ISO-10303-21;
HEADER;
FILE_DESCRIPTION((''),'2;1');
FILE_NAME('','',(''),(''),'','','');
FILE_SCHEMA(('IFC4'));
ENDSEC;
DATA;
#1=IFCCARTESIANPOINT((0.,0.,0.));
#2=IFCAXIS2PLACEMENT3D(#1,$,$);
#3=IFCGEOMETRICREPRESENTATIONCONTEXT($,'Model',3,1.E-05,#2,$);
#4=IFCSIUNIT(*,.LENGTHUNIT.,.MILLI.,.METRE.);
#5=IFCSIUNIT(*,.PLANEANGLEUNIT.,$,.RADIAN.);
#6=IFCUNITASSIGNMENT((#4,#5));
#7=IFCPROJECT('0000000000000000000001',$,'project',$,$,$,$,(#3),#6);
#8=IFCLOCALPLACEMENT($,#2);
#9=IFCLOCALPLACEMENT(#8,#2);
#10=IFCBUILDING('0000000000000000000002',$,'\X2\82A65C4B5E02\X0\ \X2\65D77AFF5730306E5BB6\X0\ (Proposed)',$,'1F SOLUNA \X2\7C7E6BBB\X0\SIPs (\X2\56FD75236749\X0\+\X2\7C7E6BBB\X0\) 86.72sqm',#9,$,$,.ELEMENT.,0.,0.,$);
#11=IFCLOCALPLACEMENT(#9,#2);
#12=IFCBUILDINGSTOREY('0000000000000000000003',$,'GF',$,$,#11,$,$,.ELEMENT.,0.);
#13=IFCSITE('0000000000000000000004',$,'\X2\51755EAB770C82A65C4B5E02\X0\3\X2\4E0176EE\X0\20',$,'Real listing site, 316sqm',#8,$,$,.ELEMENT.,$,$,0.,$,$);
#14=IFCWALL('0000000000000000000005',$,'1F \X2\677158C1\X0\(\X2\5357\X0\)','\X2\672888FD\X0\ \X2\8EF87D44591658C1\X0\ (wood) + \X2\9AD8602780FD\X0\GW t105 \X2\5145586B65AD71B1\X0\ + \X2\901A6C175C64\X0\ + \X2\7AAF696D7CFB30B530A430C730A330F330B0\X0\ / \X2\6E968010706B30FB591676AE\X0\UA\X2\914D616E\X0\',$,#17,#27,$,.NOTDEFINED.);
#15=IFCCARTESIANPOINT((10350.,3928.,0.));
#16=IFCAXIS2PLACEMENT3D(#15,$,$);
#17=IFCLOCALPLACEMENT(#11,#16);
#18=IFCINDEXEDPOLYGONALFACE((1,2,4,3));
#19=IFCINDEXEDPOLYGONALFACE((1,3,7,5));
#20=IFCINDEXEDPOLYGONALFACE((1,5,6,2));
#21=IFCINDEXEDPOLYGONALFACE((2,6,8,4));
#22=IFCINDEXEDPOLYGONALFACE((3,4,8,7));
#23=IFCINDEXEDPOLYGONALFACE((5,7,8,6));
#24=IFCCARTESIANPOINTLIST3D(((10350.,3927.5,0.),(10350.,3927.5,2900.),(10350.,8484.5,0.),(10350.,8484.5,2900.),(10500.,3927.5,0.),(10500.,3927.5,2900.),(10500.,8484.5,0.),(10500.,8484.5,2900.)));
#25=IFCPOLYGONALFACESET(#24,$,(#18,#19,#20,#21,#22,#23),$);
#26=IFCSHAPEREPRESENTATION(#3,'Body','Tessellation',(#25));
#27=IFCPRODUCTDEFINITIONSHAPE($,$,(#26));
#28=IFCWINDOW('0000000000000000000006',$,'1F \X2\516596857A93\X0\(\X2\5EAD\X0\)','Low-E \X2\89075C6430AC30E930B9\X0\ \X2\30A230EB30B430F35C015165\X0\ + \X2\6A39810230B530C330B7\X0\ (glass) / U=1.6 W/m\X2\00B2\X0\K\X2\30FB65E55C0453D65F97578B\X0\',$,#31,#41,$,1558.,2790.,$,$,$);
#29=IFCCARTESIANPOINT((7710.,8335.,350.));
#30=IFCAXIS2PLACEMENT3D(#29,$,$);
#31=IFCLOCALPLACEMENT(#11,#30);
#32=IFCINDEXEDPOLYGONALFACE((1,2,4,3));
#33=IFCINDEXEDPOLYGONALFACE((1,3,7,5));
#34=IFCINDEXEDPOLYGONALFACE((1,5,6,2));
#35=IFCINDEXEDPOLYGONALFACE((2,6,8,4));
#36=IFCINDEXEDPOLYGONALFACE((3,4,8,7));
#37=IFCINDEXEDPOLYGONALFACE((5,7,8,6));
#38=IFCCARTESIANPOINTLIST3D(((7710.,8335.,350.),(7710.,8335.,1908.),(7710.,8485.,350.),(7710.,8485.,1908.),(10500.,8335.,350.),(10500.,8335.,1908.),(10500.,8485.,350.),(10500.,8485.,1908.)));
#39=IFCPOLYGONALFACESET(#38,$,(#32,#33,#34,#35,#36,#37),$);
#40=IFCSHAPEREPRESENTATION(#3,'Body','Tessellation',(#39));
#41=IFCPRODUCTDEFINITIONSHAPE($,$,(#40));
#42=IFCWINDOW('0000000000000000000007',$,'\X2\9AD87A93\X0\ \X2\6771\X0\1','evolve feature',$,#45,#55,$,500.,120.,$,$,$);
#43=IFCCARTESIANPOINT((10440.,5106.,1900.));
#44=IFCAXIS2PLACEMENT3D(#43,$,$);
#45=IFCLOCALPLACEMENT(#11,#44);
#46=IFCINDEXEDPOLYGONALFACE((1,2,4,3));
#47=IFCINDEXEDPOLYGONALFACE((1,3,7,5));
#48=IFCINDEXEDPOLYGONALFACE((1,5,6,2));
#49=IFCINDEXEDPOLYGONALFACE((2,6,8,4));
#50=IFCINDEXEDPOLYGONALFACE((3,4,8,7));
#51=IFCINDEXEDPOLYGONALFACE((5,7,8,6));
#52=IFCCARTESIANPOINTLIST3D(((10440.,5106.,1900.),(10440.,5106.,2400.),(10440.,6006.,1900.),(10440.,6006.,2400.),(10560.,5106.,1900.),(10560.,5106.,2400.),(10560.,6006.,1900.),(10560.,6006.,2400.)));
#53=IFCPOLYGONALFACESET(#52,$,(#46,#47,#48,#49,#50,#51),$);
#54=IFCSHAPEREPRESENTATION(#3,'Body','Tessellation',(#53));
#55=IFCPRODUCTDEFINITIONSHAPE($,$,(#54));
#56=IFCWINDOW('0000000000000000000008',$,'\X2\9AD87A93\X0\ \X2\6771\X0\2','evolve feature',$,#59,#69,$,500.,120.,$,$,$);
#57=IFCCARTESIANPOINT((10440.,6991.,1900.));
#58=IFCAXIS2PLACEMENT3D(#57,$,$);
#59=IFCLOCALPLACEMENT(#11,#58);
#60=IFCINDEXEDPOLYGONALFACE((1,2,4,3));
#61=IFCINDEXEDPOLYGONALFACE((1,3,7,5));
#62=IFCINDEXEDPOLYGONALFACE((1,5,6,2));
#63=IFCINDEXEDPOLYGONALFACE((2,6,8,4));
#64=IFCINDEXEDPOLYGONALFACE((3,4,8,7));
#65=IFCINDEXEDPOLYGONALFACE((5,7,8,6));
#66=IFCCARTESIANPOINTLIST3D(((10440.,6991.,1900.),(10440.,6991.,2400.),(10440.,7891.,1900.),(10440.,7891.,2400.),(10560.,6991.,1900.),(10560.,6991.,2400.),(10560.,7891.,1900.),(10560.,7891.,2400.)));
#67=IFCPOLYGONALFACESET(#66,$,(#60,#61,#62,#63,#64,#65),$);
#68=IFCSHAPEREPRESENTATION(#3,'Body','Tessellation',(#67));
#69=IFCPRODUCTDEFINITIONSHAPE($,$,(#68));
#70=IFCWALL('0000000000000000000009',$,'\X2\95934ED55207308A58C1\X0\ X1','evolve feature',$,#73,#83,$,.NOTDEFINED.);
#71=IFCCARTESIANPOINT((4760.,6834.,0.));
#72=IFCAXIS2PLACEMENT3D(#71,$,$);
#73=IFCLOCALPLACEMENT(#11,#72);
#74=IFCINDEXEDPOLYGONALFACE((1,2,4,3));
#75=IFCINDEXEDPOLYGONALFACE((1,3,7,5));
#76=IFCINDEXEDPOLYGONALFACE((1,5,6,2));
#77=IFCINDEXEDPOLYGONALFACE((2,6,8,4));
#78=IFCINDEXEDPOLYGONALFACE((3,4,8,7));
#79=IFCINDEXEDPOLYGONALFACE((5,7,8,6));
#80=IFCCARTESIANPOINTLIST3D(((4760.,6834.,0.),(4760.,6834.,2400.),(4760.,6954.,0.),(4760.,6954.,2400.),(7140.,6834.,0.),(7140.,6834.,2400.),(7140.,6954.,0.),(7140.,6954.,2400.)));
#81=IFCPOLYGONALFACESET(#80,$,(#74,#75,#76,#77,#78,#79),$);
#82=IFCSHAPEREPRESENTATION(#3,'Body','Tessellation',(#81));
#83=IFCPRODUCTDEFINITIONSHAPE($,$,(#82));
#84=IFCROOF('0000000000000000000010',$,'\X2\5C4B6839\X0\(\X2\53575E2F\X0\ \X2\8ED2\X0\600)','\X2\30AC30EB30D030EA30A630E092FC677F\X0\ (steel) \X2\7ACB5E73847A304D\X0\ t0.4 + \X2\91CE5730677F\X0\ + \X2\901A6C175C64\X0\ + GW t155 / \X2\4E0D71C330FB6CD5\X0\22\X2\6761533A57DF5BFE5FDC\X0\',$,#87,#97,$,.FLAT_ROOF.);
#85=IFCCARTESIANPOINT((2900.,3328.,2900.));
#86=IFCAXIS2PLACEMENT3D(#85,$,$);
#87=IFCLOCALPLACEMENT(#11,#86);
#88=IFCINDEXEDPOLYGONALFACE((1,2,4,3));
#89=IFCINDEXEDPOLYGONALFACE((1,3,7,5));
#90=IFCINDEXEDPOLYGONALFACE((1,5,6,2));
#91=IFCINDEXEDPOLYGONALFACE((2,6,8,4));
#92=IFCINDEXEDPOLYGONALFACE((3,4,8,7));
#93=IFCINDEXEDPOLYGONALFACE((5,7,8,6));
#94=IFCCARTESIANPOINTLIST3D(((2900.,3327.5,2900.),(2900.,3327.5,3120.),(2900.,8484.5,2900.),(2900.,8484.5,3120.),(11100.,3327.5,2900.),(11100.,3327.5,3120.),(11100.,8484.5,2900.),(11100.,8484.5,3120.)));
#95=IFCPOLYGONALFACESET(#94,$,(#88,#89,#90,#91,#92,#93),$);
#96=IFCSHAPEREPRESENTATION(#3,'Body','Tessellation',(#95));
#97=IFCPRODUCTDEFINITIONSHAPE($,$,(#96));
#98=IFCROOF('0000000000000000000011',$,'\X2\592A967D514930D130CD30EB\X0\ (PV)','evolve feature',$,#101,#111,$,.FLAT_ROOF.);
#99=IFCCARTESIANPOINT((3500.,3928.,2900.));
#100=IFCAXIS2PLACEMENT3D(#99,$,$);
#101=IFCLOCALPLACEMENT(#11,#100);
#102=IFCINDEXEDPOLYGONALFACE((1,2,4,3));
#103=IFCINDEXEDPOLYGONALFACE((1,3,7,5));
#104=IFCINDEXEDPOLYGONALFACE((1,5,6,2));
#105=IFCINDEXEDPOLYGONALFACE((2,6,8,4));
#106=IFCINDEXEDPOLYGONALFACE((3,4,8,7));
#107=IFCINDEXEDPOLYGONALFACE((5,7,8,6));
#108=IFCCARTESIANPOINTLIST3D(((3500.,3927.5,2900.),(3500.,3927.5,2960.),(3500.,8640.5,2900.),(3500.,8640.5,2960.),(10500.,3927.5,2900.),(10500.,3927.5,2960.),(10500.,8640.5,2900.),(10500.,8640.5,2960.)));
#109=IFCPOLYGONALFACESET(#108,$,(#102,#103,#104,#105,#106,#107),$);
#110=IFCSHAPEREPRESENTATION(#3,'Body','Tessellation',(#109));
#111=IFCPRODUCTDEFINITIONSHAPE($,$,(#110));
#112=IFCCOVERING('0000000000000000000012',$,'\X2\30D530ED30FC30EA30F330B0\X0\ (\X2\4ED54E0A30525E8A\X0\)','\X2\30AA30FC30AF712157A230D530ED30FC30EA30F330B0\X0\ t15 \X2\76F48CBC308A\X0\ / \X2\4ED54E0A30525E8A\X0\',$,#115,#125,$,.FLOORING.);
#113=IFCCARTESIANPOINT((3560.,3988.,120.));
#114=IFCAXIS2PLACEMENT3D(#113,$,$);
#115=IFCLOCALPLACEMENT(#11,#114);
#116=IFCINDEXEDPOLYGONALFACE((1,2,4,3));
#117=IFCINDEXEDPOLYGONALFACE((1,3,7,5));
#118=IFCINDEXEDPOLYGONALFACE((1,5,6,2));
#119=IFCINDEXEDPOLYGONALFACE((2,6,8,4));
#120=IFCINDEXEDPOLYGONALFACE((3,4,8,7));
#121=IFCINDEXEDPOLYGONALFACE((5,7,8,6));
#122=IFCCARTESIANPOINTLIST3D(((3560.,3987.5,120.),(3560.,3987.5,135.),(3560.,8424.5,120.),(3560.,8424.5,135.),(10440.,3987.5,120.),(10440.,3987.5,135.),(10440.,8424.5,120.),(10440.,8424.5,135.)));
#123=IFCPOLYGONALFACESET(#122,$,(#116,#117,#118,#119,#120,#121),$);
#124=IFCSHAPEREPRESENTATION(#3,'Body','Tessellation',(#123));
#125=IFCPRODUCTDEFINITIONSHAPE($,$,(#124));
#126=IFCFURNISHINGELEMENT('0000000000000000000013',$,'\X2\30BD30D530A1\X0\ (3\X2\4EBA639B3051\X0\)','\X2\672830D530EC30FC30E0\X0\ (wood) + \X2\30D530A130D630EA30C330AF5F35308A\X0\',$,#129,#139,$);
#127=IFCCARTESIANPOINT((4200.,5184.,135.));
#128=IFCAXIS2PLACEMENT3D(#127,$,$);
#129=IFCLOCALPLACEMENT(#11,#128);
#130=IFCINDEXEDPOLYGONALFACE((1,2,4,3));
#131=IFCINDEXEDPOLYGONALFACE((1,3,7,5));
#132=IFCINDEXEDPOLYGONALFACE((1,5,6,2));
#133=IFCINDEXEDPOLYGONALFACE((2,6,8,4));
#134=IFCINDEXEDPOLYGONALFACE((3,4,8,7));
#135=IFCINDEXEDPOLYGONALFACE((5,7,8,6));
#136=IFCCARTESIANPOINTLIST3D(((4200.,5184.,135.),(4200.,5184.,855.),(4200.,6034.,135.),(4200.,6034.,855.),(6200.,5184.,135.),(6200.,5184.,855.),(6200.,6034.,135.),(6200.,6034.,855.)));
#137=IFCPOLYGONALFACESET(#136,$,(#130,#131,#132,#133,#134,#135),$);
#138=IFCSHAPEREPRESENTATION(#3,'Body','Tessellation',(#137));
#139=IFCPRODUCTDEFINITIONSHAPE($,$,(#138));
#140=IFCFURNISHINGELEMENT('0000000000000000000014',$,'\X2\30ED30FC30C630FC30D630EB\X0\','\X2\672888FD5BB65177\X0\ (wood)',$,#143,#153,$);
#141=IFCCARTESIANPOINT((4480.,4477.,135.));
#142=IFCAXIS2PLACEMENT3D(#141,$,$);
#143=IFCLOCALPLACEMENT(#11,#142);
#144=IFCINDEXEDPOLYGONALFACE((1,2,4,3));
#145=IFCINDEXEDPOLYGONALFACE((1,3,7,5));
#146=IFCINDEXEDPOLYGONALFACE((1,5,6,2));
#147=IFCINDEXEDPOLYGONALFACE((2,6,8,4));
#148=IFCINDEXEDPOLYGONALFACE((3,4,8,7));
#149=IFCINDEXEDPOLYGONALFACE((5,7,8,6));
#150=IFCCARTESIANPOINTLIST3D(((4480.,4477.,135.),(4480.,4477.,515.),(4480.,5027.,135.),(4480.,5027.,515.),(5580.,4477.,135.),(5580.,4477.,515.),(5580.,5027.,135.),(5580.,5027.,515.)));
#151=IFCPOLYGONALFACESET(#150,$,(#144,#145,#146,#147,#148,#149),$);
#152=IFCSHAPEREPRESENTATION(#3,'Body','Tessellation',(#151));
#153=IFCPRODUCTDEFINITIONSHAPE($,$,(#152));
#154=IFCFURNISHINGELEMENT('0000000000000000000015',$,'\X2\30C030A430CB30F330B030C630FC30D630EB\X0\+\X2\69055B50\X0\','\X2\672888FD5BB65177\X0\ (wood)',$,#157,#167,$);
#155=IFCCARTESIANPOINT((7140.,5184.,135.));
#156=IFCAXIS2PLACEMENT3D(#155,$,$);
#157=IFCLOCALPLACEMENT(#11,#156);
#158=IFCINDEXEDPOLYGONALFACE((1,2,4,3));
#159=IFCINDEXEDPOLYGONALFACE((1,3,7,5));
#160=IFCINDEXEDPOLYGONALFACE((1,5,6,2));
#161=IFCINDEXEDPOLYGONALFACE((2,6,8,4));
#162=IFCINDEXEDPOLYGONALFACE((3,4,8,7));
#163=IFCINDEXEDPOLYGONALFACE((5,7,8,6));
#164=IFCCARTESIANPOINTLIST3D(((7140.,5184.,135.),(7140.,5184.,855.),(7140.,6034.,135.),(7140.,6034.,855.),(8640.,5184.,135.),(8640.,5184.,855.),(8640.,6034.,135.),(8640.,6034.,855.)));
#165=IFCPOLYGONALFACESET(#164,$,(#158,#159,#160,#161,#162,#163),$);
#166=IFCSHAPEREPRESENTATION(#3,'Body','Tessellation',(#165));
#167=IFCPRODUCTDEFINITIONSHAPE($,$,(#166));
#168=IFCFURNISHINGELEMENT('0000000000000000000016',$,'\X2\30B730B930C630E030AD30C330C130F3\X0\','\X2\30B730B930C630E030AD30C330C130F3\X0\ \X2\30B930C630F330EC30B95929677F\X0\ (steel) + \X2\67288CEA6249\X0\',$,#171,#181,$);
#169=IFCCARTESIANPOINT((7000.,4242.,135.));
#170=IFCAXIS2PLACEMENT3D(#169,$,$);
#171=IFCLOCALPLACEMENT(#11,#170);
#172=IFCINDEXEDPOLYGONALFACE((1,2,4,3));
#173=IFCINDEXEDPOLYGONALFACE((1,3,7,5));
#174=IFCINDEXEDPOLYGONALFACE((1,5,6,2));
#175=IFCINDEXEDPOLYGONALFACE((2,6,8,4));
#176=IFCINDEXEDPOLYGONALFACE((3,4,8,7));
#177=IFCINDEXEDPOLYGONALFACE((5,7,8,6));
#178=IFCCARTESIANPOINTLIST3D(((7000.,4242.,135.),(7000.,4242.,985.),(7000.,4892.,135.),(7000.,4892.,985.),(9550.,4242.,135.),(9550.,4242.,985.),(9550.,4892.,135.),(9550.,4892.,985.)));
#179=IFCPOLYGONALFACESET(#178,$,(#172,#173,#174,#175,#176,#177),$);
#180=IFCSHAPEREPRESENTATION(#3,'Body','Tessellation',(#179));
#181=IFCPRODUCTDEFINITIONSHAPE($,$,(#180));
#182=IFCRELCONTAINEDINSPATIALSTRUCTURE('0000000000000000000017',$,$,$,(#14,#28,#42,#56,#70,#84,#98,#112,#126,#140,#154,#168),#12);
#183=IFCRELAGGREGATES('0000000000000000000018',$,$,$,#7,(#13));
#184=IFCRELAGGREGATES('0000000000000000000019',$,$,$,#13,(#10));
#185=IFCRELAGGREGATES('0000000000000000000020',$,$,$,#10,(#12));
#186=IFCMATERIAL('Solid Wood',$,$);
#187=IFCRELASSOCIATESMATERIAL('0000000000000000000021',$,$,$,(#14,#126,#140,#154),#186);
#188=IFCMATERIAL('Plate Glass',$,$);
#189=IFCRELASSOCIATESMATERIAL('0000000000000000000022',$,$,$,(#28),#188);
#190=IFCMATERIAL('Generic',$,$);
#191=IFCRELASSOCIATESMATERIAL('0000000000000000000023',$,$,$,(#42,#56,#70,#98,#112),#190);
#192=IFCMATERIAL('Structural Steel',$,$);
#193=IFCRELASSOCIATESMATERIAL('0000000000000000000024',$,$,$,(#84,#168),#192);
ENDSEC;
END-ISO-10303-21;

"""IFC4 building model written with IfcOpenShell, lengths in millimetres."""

from ifc_helpers import new_model, si_unit, frame, frame_2d, origin, place, context, project, spatial, rectangle, extrude, material, element, fill, save


model = new_model("IFC4")

# Units and contexts
model_context = context("Model", 3, precision=1e-05, world=origin())
ifc_project = project(units=[si_unit("LENGTHUNIT", "METRE", prefix="MILLI"), si_unit("PLANEANGLEUNIT", "RADIAN")], contexts=[model_context])

# Site, building, storey
site_placement = place(None, origin())
site = spatial("IfcSite", under=ifc_project, at=site_placement, Name="兵庫県芦屋市3丁目20", ObjectType="Real listing site, 316sqm", CompositionType="ELEMENT", RefElevation=0.0)
building_placement = place(site_placement, origin())
building = spatial("IfcBuilding", under=site, at=building_placement, Name="芦屋市 旗竿地の家 (Proposed)", ObjectType="1F SOLUNA 籾殻SIPs (国産杉+籾殻) 86.72sqm", CompositionType="ELEMENT", ElevationOfRefHeight=0.0, ElevationOfTerrain=0.0)
storey_placement = place(building_placement, origin())
storey = spatial("IfcBuildingStorey", under=building, at=storey_placement, Name="GF", CompositionType="ELEMENT", Elevation=0.0)

# Shared definitions
ifc_material_1 = material(Name="Solid Wood")
ifc_material_2 = material(Name="Generic")

# Shared definitions
ifc_material_3 = material(Name="Plate Glass")

# Wall, openings, windows
wall_1_placement = place(storey_placement, frame((10350.0, 3928.0, 0.0)))
wall_1 = element("IfcWall", 1, at=wall_1_placement, inside=storey, material=ifc_material_1, Name="1F 東壁(南)", Description="木製 軸組外壁 (wood) + 高性能GW t105 充填断熱 + 通気層 + 窯業系サイディング / 準耐火・外皮UA配慮", PredefinedType="NOTDEFINED", context=model_context, shape_type="SweptSolid", body=[
    extrude(rectangle(XDim=150.0, YDim=4557.0, at=frame_2d((75.0, 2278.0))), frame((10350.0, 3928.0, 0.0)), (0.0, 0.0, 1.0), 2900.0),
])
opening_1_placement = place(storey_placement, frame((7710.0, 8335.0, 350.0)))
opening_1 = element("IfcOpeningElement", 2, at=opening_1_placement, cuts=wall_1, PredefinedType="NOTDEFINED", context=model_context, shape_type="SweptSolid", body=[
    extrude(rectangle(XDim=2790.0, YDim=150.0, at=frame_2d((1395.0, 75.0))), frame((7710.0, 8335.0, 350.0)), (0.0, 0.0, 1.0), 1558.0),
])
opening_2_placement = place(storey_placement, frame((10440.0, 5106.0, 1900.0)))
opening_2 = element("IfcOpeningElement", 3, at=opening_2_placement, cuts=wall_1, PredefinedType="NOTDEFINED", context=model_context, shape_type="SweptSolid", body=[
    extrude(rectangle(XDim=120.0, YDim=900.0, at=frame_2d((60.0, 450.0))), frame((10440.0, 5106.0, 1900.0)), (0.0, 0.0, 1.0), 500.0),
])
opening_3_placement = place(storey_placement, frame((10440.0, 6991.0, 1900.0)))
opening_3 = element("IfcOpeningElement", 4, at=opening_3_placement, cuts=wall_1, PredefinedType="NOTDEFINED", context=model_context, shape_type="SweptSolid", body=[
    extrude(rectangle(XDim=120.0, YDim=900.0, at=frame_2d((60.0, 450.0))), frame((10440.0, 6991.0, 1900.0)), (0.0, 0.0, 1.0), 500.0),
])
window_1_placement = place(storey_placement, frame((7710.0, 8335.0, 350.0)))
window_1 = element("IfcWindow", 5, at=window_1_placement, inside=storey, material=ifc_material_3, Name="1F 入隅窓(庭)", Description="Low-E 複層ガラス アルゴン封入 + 樹脂サッシ (glass) / U=1.6 W/m²K・日射取得型", OverallHeight=1558.0, OverallWidth=2790.0, context=model_context, shape_type="SweptSolid", body=[
    extrude(rectangle(XDim=2790.0, YDim=150.0, at=frame_2d((1395.0, 75.0))), frame((7710.0, 8335.0, 350.0)), (0.0, 0.0, 1.0), 1558.0),
])
fill(opening_1, window_1)
window_2_placement = place(storey_placement, frame((10440.0, 5106.0, 1900.0)))
window_2 = element("IfcWindow", 6, at=window_2_placement, inside=storey, material=ifc_material_2, Name="高窓 東1", Description="evolve feature", OverallHeight=500.0, OverallWidth=120.0, context=model_context, shape_type="SweptSolid", body=[
    extrude(rectangle(XDim=120.0, YDim=900.0, at=frame_2d((60.0, 450.0))), frame((10440.0, 5106.0, 1900.0)), (0.0, 0.0, 1.0), 500.0),
])
fill(opening_2, window_2)
window_3_placement = place(storey_placement, frame((10440.0, 6991.0, 1900.0)))
window_3 = element("IfcWindow", 7, at=window_3_placement, inside=storey, material=ifc_material_2, Name="高窓 東2", Description="evolve feature", OverallHeight=500.0, OverallWidth=120.0, context=model_context, shape_type="SweptSolid", body=[
    extrude(rectangle(XDim=120.0, YDim=900.0, at=frame_2d((60.0, 450.0))), frame((10440.0, 6991.0, 1900.0)), (0.0, 0.0, 1.0), 500.0),
])
fill(opening_3, window_3)

# Wall
wall_2_placement = place(storey_placement, frame((4760.0, 6834.0, 0.0)))
element("IfcWall", 8, at=wall_2_placement, inside=storey, material=ifc_material_2, Name="間仕切り壁 X1", Description="evolve feature", PredefinedType="NOTDEFINED", context=model_context, shape_type="SweptSolid", body=[
    extrude(rectangle(XDim=2380.0, YDim=120.0, at=frame_2d((1190.0, 60.0))), frame((4760.0, 6834.0, 0.0)), (0.0, 0.0, 1.0), 2400.0),
])

# Roofs
ifc_material_4 = material(Name="Structural Steel")
roof_1_placement = place(storey_placement, frame((2900.0, 3328.0, 2900.0)))
element("IfcRoof", 9, at=roof_1_placement, inside=storey, material=ifc_material_4, Name="屋根(南帯 軒600)", Description="ガルバリウム鋼板 (steel) 立平葺き t0.4 + 野地板 + 通気層 + GW t155 / 不燃・法22条区域対応", PredefinedType="FLAT_ROOF", context=model_context, shape_type="SweptSolid", body=[
    extrude(rectangle(XDim=8200.0, YDim=5157.0, at=frame_2d((4100.0, 2578.0))), frame((2900.0, 3328.0, 2900.0)), (0.0, 0.0, 1.0), 220.0),
])
roof_2_placement = place(storey_placement, frame((3500.0, 3928.0, 2900.0)))
element("IfcRoof", 10, at=roof_2_placement, inside=storey, material=ifc_material_2, Name="太陽光パネル (PV)", Description="evolve feature", PredefinedType="FLAT_ROOF", context=model_context, shape_type="SweptSolid", body=[
    extrude(rectangle(XDim=7000.0, YDim=4713.0, at=frame_2d((3500.0, 2356.0))), frame((3500.0, 3928.0, 2900.0)), (0.0, 0.0, 1.0), 60.0),
])

# Covering
covering_placement = place(storey_placement, frame((3560.0, 3988.0, 120.0)))
element("IfcCovering", 11, at=covering_placement, inside=storey, material=ifc_material_2, Name="フローリング (仕上げ床)", Description="オーク無垢フローリング t15 直貼り / 仕上げ床", PredefinedType="FLOORING", context=model_context, shape_type="SweptSolid", body=[
    extrude(rectangle(XDim=6880.0, YDim=4437.0, at=frame_2d((3440.0, 2218.0))), frame((3560.0, 3988.0, 120.0)), (0.0, 0.0, 1.0), 15.0),
])

# Furnishing elements
furnishing_1_placement = place(storey_placement, frame((4200.0, 5184.0, 135.0)))
element("IfcFurnishingElement", 12, at=furnishing_1_placement, inside=storey, material=ifc_material_1, Name="ソファ (3人掛け)", Description="木フレーム (wood) + ファブリック張り", context=model_context, shape_type="SweptSolid", body=[
    extrude(rectangle(XDim=2000.0, YDim=850.0, at=frame_2d((1000.0, 425.0))), frame((4200.0, 5184.0, 135.0)), (0.0, 0.0, 1.0), 720.0),
])
furnishing_2_placement = place(storey_placement, frame((4480.0, 4477.0, 135.0)))
element("IfcFurnishingElement", 13, at=furnishing_2_placement, inside=storey, material=ifc_material_1, Name="ローテーブル", Description="木製家具 (wood)", context=model_context, shape_type="SweptSolid", body=[
    extrude(rectangle(XDim=1100.0, YDim=550.0, at=frame_2d((550.0, 275.0))), frame((4480.0, 4477.0, 135.0)), (0.0, 0.0, 1.0), 380.0),
])
furnishing_3_placement = place(storey_placement, frame((7140.0, 5184.0, 135.0)))
element("IfcFurnishingElement", 14, at=furnishing_3_placement, inside=storey, material=ifc_material_1, Name="ダイニングテーブル+椅子", Description="木製家具 (wood)", context=model_context, shape_type="SweptSolid", body=[
    extrude(rectangle(XDim=1500.0, YDim=850.0, at=frame_2d((750.0, 425.0))), frame((7140.0, 5184.0, 135.0)), (0.0, 0.0, 1.0), 720.0),
])
furnishing_4_placement = place(storey_placement, frame((7000.0, 4242.0, 135.0)))
element("IfcFurnishingElement", 15, at=furnishing_4_placement, inside=storey, material=ifc_material_4, Name="システムキッチン", Description="システムキッチン ステンレス天板 (steel) + 木質扉", context=model_context, shape_type="SweptSolid", body=[
    extrude(rectangle(XDim=2550.0, YDim=650.0, at=frame_2d((1275.0, 325.0))), frame((7000.0, 4242.0, 135.0)), (0.0, 0.0, 1.0), 850.0),
])

save(model, "model.ifc")
